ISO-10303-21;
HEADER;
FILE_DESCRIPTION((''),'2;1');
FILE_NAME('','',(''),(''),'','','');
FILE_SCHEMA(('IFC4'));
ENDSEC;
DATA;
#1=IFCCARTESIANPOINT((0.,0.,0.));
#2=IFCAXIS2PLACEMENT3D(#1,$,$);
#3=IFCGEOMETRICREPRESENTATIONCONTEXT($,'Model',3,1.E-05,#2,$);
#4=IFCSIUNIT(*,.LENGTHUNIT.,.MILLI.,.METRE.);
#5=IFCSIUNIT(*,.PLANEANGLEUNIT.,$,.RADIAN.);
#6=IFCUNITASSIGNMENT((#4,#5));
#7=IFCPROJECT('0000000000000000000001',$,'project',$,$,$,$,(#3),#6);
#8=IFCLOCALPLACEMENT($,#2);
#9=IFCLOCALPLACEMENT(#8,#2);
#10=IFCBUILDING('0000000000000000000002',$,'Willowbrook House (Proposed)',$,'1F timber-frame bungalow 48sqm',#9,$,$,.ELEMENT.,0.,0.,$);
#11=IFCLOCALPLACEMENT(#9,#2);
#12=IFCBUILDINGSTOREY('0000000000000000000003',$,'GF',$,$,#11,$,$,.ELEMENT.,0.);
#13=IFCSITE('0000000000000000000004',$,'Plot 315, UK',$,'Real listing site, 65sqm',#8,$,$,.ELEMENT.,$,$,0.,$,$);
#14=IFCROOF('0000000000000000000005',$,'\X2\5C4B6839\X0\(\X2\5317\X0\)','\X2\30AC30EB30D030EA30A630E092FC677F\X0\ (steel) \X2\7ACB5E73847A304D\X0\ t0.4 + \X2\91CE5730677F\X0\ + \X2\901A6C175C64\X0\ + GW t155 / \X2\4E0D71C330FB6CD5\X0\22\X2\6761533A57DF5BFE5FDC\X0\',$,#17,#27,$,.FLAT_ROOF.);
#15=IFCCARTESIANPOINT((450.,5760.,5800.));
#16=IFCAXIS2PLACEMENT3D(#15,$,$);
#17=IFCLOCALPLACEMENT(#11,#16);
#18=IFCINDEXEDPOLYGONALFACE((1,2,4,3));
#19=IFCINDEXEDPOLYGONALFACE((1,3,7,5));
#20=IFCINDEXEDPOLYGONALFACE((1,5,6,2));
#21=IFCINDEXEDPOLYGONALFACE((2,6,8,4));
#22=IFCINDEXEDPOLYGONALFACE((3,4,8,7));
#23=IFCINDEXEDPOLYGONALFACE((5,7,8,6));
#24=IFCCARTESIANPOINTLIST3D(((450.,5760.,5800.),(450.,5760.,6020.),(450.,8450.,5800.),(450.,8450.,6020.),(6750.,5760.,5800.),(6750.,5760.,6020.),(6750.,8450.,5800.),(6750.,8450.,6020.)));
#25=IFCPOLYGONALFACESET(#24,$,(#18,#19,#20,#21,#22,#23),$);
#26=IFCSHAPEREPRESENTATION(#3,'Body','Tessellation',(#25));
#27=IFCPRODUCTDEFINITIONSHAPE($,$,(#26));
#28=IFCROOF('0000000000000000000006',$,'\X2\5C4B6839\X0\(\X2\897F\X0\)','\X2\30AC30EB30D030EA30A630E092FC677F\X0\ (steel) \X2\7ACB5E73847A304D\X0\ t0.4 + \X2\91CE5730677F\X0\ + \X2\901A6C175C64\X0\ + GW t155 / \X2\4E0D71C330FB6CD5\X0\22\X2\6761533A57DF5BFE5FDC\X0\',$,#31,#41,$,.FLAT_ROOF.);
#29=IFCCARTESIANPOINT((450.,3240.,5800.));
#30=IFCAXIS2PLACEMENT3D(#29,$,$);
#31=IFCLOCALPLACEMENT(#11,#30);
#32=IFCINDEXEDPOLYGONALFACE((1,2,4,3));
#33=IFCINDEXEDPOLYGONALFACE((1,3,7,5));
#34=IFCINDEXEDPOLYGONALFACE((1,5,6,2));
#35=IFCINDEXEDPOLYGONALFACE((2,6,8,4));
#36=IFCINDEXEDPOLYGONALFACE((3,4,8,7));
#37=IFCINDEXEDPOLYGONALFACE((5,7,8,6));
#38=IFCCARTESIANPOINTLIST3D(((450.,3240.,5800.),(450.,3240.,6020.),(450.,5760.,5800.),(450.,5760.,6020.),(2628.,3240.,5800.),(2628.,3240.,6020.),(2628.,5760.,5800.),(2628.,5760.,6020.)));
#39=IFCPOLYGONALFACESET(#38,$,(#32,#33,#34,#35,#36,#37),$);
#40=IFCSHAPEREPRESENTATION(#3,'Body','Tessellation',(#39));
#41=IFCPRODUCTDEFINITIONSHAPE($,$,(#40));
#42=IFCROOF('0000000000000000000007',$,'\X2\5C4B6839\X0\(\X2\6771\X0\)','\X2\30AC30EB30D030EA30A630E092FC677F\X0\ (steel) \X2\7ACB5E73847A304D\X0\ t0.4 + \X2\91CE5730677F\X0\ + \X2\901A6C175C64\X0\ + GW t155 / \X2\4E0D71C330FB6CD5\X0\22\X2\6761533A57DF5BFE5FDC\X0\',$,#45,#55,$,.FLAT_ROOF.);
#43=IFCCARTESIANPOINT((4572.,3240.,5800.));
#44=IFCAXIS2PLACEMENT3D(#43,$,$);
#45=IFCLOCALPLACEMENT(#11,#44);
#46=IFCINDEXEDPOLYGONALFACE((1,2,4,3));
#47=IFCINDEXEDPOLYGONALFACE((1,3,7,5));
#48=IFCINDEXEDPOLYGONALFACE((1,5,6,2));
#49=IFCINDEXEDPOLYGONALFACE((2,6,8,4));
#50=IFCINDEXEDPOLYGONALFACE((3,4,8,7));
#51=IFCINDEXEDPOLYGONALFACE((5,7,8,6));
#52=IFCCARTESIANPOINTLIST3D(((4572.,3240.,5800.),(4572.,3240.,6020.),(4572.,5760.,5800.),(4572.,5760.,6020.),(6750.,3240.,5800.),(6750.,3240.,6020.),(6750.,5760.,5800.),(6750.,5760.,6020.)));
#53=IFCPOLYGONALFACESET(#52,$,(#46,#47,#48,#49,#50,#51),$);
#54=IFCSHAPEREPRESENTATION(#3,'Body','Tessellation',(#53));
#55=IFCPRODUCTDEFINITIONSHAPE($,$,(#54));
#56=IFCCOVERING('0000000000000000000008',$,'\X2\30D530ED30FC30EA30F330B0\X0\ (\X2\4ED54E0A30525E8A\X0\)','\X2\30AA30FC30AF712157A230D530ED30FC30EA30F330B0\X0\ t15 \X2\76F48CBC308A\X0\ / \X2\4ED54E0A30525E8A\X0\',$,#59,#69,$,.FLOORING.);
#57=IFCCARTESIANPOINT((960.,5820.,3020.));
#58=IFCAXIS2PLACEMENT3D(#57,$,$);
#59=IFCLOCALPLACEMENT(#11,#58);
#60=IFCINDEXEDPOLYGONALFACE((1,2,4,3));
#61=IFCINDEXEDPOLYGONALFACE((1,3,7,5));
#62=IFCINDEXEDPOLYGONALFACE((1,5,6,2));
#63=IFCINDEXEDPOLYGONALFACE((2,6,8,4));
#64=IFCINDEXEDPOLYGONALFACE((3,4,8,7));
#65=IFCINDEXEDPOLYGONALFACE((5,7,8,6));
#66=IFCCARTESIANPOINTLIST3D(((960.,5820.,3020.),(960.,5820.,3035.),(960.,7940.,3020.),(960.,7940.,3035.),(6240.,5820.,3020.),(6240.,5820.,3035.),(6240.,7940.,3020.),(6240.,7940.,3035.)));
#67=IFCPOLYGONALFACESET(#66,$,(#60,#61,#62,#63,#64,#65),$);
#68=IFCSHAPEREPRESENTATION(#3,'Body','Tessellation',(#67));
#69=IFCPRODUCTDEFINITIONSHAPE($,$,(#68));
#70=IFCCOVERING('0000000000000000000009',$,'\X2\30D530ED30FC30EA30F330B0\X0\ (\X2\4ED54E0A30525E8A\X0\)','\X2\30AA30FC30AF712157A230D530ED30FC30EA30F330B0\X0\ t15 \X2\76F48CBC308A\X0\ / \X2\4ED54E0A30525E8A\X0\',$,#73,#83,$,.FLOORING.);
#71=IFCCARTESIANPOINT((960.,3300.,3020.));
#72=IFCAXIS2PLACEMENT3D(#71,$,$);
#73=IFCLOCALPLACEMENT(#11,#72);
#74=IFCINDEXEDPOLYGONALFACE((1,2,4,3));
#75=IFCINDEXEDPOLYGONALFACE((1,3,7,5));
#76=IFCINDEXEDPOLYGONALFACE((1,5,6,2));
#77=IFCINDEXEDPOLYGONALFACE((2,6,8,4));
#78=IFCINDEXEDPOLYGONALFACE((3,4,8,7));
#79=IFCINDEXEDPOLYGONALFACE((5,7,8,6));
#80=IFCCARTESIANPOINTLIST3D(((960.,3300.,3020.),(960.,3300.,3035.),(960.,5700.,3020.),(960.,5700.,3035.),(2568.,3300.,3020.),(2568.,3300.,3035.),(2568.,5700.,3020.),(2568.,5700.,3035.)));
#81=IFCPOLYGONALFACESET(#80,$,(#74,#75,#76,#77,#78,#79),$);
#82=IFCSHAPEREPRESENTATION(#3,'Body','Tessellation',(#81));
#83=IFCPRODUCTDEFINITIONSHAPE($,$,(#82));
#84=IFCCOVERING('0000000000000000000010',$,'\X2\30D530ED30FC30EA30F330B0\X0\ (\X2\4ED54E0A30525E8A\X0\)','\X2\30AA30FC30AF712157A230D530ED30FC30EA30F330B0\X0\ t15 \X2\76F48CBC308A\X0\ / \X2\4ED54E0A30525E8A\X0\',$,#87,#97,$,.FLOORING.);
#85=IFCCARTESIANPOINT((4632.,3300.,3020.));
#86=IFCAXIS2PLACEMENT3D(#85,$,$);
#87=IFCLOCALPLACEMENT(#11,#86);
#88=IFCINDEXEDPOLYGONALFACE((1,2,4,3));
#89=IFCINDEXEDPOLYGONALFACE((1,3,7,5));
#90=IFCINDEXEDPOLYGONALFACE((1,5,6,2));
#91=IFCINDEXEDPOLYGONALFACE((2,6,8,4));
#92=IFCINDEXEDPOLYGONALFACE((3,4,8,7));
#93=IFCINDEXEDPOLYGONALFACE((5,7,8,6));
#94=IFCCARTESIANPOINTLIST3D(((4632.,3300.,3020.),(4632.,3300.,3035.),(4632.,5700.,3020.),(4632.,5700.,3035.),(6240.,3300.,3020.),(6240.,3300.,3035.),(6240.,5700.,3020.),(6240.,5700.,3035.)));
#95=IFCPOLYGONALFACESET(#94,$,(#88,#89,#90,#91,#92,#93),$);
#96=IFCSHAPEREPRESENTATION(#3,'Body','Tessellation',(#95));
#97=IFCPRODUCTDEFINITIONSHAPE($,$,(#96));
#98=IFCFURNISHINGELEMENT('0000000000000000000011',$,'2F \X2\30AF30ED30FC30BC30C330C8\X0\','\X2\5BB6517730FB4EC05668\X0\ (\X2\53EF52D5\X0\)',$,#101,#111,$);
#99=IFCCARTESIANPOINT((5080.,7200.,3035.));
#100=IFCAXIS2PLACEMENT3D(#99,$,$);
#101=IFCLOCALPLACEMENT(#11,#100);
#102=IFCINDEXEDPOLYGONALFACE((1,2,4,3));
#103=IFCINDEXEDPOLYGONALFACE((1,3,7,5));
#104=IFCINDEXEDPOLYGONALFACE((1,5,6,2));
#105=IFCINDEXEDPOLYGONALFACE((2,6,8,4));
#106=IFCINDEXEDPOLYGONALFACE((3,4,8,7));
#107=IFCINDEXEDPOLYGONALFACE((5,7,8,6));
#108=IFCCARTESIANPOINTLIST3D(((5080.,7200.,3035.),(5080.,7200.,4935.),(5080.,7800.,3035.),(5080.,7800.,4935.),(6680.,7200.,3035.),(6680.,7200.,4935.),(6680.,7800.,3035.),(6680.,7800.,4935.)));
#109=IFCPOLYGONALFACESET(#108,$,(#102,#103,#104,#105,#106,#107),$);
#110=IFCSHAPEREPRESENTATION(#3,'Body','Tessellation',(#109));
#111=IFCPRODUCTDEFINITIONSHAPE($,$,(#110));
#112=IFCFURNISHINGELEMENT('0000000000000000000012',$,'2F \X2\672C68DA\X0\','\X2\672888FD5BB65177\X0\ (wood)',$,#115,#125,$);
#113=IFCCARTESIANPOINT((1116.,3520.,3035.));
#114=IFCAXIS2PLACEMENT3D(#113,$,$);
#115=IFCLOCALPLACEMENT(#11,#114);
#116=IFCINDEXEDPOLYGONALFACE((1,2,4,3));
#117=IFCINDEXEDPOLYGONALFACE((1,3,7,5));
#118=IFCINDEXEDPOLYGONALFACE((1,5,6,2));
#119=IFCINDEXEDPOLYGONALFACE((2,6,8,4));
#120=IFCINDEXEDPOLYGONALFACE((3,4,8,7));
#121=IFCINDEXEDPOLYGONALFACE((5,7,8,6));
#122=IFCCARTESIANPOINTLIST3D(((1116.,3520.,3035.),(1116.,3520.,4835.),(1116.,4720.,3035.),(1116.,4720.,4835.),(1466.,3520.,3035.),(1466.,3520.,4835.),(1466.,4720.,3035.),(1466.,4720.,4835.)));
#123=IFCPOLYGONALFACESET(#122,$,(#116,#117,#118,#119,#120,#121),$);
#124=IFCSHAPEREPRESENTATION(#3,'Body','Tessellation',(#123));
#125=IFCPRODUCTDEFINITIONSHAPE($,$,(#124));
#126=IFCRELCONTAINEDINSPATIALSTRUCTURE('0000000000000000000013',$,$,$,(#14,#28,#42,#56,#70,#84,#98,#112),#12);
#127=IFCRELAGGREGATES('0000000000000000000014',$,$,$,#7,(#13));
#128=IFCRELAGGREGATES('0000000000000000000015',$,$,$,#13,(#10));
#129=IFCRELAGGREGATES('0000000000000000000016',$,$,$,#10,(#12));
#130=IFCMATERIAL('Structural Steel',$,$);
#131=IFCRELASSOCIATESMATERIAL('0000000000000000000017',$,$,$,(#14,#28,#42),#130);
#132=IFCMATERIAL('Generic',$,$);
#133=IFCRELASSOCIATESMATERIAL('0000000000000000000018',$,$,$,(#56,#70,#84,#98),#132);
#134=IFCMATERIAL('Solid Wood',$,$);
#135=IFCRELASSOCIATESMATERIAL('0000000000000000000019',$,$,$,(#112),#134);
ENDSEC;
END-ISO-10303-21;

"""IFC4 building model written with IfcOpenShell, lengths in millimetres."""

from ifc_helpers import new_model, si_unit, frame, frame_2d, origin, place, context, project, spatial, rectangle, extrude, material, element, save


model = new_model("IFC4")

# Units and contexts
model_context = context("Model", 3, precision=1e-05, world=origin())
ifc_project = project(units=[si_unit("LENGTHUNIT", "METRE", prefix="MILLI"), si_unit("PLANEANGLEUNIT", "RADIAN")], contexts=[model_context])

# Site, building, storey
site_placement = place(None, origin())
site = spatial("IfcSite", under=ifc_project, at=site_placement, Name="Plot 315, UK", ObjectType="Real listing site, 65sqm", CompositionType="ELEMENT", RefElevation=0.0)
building_placement = place(site_placement, origin())
building = spatial("IfcBuilding", under=site, at=building_placement, Name="Willowbrook House (Proposed)", ObjectType="1F timber-frame bungalow 48sqm", CompositionType="ELEMENT", ElevationOfRefHeight=0.0, ElevationOfTerrain=0.0)
storey_placement = place(building_placement, origin())
storey = spatial("IfcBuildingStorey", under=building, at=storey_placement, Name="GF", CompositionType="ELEMENT", Elevation=0.0)

# Shared definitions
ifc_material_1 = material(Name="Solid Wood")

# Roofs
ifc_material_2 = material(Name="Structural Steel")
for number, where, name in (
    (1, (450.0, 5760.0, 5800.0), "屋根(北)"),
):
    element("IfcRoof", number, at=place(storey_placement, frame(where)), inside=storey, material=ifc_material_2, Name=name, Description="ガルバリウム鋼板 (steel) 立平葺き t0.4 + 野地板 + 通気層 + GW t155 / 不燃・法22条区域対応", PredefinedType="FLAT_ROOF", context=model_context, shape_type="SweptSolid", body=[
        extrude(rectangle(XDim=6300.0, YDim=2690.0, at=frame_2d((3150.0, 1345.0))), frame((450.0, 5760.0, 5800.0)), (0.0, 0.0, 1.0), 220.0),
    ])
roof_1_placement = place(storey_placement, frame((450.0, 3240.0, 5800.0)))
element("IfcRoof", 2, at=roof_1_placement, inside=storey, material=ifc_material_2, Name="屋根(西)", Description="ガルバリウム鋼板 (steel) 立平葺き t0.4 + 野地板 + 通気層 + GW t155 / 不燃・法22条区域対応", PredefinedType="FLAT_ROOF", context=model_context, shape_type="SweptSolid", body=[
    extrude(rectangle(XDim=2178.0, YDim=2520.0, at=frame_2d((1089.0, 1260.0))), frame((450.0, 3240.0, 5800.0)), (0.0, 0.0, 1.0), 220.0),
])
roof_2_placement = place(storey_placement, frame((4572.0, 3240.0, 5800.0)))
element("IfcRoof", 3, at=roof_2_placement, inside=storey, material=ifc_material_2, Name="屋根(東)", Description="ガルバリウム鋼板 (steel) 立平葺き t0.4 + 野地板 + 通気層 + GW t155 / 不燃・法22条区域対応", PredefinedType="FLAT_ROOF", context=model_context, shape_type="SweptSolid", body=[
    extrude(rectangle(XDim=2178.0, YDim=2520.0, at=frame_2d((1089.0, 1260.0))), frame((4572.0, 3240.0, 5800.0)), (0.0, 0.0, 1.0), 220.0),
])

# Coverings
ifc_material_3 = material(Name="Generic")
covering_1_placement = place(storey_placement, frame((960.0, 5820.0, 3020.0)))
element("IfcCovering", 4, at=covering_1_placement, inside=storey, material=ifc_material_3, Name="フローリング (仕上げ床)", Description="オーク無垢フローリング t15 直貼り / 仕上げ床", PredefinedType="FLOORING", context=model_context, shape_type="SweptSolid", body=[
    extrude(rectangle(XDim=5280.0, YDim=2120.0, at=frame_2d((2640.0, 1060.0))), frame((960.0, 5820.0, 3020.0)), (0.0, 0.0, 1.0), 15.0),
])
covering_2_placement = place(storey_placement, frame((960.0, 3300.0, 3020.0)))
element("IfcCovering", 5, at=covering_2_placement, inside=storey, material=ifc_material_3, Name="フローリング (仕上げ床)", Description="オーク無垢フローリング t15 直貼り / 仕上げ床", PredefinedType="FLOORING", context=model_context, shape_type="SweptSolid", body=[
    extrude(rectangle(XDim=1608.0, YDim=2400.0, at=frame_2d((804.0, 1200.0))), frame((960.0, 3300.0, 3020.0)), (0.0, 0.0, 1.0), 15.0),
])
covering_3_placement = place(storey_placement, frame((4632.0, 3300.0, 3020.0)))
element("IfcCovering", 6, at=covering_3_placement, inside=storey, material=ifc_material_3, Name="フローリング (仕上げ床)", Description="オーク無垢フローリング t15 直貼り / 仕上げ床", PredefinedType="FLOORING", context=model_context, shape_type="SweptSolid", body=[
    extrude(rectangle(XDim=1608.0, YDim=2400.0, at=frame_2d((804.0, 1200.0))), frame((4632.0, 3300.0, 3020.0)), (0.0, 0.0, 1.0), 15.0),
])

# Furnishing elements
furnishing_1_placement = place(storey_placement, frame((5080.0, 7200.0, 3035.0)))
element("IfcFurnishingElement", 7, at=furnishing_1_placement, inside=storey, material=ifc_material_3, Name="2F クローゼット", Description="家具・什器 (可動)", context=model_context, shape_type="SweptSolid", body=[
    extrude(rectangle(XDim=1600.0, YDim=600.0, at=frame_2d((800.0, 300.0))), frame((5080.0, 7200.0, 3035.0)), (0.0, 0.0, 1.0), 1900.0),
])
furnishing_2_placement = place(storey_placement, frame((1116.0, 3520.0, 3035.0)))
element("IfcFurnishingElement", 8, at=furnishing_2_placement, inside=storey, material=ifc_material_1, Name="2F 本棚", Description="木製家具 (wood)", context=model_context, shape_type="SweptSolid", body=[
    extrude(rectangle(XDim=350.0, YDim=1200.0, at=frame_2d((175.0, 600.0))), frame((1116.0, 3520.0, 3035.0)), (0.0, 0.0, 1.0), 1800.0),
])

save(model, "model.ifc")
